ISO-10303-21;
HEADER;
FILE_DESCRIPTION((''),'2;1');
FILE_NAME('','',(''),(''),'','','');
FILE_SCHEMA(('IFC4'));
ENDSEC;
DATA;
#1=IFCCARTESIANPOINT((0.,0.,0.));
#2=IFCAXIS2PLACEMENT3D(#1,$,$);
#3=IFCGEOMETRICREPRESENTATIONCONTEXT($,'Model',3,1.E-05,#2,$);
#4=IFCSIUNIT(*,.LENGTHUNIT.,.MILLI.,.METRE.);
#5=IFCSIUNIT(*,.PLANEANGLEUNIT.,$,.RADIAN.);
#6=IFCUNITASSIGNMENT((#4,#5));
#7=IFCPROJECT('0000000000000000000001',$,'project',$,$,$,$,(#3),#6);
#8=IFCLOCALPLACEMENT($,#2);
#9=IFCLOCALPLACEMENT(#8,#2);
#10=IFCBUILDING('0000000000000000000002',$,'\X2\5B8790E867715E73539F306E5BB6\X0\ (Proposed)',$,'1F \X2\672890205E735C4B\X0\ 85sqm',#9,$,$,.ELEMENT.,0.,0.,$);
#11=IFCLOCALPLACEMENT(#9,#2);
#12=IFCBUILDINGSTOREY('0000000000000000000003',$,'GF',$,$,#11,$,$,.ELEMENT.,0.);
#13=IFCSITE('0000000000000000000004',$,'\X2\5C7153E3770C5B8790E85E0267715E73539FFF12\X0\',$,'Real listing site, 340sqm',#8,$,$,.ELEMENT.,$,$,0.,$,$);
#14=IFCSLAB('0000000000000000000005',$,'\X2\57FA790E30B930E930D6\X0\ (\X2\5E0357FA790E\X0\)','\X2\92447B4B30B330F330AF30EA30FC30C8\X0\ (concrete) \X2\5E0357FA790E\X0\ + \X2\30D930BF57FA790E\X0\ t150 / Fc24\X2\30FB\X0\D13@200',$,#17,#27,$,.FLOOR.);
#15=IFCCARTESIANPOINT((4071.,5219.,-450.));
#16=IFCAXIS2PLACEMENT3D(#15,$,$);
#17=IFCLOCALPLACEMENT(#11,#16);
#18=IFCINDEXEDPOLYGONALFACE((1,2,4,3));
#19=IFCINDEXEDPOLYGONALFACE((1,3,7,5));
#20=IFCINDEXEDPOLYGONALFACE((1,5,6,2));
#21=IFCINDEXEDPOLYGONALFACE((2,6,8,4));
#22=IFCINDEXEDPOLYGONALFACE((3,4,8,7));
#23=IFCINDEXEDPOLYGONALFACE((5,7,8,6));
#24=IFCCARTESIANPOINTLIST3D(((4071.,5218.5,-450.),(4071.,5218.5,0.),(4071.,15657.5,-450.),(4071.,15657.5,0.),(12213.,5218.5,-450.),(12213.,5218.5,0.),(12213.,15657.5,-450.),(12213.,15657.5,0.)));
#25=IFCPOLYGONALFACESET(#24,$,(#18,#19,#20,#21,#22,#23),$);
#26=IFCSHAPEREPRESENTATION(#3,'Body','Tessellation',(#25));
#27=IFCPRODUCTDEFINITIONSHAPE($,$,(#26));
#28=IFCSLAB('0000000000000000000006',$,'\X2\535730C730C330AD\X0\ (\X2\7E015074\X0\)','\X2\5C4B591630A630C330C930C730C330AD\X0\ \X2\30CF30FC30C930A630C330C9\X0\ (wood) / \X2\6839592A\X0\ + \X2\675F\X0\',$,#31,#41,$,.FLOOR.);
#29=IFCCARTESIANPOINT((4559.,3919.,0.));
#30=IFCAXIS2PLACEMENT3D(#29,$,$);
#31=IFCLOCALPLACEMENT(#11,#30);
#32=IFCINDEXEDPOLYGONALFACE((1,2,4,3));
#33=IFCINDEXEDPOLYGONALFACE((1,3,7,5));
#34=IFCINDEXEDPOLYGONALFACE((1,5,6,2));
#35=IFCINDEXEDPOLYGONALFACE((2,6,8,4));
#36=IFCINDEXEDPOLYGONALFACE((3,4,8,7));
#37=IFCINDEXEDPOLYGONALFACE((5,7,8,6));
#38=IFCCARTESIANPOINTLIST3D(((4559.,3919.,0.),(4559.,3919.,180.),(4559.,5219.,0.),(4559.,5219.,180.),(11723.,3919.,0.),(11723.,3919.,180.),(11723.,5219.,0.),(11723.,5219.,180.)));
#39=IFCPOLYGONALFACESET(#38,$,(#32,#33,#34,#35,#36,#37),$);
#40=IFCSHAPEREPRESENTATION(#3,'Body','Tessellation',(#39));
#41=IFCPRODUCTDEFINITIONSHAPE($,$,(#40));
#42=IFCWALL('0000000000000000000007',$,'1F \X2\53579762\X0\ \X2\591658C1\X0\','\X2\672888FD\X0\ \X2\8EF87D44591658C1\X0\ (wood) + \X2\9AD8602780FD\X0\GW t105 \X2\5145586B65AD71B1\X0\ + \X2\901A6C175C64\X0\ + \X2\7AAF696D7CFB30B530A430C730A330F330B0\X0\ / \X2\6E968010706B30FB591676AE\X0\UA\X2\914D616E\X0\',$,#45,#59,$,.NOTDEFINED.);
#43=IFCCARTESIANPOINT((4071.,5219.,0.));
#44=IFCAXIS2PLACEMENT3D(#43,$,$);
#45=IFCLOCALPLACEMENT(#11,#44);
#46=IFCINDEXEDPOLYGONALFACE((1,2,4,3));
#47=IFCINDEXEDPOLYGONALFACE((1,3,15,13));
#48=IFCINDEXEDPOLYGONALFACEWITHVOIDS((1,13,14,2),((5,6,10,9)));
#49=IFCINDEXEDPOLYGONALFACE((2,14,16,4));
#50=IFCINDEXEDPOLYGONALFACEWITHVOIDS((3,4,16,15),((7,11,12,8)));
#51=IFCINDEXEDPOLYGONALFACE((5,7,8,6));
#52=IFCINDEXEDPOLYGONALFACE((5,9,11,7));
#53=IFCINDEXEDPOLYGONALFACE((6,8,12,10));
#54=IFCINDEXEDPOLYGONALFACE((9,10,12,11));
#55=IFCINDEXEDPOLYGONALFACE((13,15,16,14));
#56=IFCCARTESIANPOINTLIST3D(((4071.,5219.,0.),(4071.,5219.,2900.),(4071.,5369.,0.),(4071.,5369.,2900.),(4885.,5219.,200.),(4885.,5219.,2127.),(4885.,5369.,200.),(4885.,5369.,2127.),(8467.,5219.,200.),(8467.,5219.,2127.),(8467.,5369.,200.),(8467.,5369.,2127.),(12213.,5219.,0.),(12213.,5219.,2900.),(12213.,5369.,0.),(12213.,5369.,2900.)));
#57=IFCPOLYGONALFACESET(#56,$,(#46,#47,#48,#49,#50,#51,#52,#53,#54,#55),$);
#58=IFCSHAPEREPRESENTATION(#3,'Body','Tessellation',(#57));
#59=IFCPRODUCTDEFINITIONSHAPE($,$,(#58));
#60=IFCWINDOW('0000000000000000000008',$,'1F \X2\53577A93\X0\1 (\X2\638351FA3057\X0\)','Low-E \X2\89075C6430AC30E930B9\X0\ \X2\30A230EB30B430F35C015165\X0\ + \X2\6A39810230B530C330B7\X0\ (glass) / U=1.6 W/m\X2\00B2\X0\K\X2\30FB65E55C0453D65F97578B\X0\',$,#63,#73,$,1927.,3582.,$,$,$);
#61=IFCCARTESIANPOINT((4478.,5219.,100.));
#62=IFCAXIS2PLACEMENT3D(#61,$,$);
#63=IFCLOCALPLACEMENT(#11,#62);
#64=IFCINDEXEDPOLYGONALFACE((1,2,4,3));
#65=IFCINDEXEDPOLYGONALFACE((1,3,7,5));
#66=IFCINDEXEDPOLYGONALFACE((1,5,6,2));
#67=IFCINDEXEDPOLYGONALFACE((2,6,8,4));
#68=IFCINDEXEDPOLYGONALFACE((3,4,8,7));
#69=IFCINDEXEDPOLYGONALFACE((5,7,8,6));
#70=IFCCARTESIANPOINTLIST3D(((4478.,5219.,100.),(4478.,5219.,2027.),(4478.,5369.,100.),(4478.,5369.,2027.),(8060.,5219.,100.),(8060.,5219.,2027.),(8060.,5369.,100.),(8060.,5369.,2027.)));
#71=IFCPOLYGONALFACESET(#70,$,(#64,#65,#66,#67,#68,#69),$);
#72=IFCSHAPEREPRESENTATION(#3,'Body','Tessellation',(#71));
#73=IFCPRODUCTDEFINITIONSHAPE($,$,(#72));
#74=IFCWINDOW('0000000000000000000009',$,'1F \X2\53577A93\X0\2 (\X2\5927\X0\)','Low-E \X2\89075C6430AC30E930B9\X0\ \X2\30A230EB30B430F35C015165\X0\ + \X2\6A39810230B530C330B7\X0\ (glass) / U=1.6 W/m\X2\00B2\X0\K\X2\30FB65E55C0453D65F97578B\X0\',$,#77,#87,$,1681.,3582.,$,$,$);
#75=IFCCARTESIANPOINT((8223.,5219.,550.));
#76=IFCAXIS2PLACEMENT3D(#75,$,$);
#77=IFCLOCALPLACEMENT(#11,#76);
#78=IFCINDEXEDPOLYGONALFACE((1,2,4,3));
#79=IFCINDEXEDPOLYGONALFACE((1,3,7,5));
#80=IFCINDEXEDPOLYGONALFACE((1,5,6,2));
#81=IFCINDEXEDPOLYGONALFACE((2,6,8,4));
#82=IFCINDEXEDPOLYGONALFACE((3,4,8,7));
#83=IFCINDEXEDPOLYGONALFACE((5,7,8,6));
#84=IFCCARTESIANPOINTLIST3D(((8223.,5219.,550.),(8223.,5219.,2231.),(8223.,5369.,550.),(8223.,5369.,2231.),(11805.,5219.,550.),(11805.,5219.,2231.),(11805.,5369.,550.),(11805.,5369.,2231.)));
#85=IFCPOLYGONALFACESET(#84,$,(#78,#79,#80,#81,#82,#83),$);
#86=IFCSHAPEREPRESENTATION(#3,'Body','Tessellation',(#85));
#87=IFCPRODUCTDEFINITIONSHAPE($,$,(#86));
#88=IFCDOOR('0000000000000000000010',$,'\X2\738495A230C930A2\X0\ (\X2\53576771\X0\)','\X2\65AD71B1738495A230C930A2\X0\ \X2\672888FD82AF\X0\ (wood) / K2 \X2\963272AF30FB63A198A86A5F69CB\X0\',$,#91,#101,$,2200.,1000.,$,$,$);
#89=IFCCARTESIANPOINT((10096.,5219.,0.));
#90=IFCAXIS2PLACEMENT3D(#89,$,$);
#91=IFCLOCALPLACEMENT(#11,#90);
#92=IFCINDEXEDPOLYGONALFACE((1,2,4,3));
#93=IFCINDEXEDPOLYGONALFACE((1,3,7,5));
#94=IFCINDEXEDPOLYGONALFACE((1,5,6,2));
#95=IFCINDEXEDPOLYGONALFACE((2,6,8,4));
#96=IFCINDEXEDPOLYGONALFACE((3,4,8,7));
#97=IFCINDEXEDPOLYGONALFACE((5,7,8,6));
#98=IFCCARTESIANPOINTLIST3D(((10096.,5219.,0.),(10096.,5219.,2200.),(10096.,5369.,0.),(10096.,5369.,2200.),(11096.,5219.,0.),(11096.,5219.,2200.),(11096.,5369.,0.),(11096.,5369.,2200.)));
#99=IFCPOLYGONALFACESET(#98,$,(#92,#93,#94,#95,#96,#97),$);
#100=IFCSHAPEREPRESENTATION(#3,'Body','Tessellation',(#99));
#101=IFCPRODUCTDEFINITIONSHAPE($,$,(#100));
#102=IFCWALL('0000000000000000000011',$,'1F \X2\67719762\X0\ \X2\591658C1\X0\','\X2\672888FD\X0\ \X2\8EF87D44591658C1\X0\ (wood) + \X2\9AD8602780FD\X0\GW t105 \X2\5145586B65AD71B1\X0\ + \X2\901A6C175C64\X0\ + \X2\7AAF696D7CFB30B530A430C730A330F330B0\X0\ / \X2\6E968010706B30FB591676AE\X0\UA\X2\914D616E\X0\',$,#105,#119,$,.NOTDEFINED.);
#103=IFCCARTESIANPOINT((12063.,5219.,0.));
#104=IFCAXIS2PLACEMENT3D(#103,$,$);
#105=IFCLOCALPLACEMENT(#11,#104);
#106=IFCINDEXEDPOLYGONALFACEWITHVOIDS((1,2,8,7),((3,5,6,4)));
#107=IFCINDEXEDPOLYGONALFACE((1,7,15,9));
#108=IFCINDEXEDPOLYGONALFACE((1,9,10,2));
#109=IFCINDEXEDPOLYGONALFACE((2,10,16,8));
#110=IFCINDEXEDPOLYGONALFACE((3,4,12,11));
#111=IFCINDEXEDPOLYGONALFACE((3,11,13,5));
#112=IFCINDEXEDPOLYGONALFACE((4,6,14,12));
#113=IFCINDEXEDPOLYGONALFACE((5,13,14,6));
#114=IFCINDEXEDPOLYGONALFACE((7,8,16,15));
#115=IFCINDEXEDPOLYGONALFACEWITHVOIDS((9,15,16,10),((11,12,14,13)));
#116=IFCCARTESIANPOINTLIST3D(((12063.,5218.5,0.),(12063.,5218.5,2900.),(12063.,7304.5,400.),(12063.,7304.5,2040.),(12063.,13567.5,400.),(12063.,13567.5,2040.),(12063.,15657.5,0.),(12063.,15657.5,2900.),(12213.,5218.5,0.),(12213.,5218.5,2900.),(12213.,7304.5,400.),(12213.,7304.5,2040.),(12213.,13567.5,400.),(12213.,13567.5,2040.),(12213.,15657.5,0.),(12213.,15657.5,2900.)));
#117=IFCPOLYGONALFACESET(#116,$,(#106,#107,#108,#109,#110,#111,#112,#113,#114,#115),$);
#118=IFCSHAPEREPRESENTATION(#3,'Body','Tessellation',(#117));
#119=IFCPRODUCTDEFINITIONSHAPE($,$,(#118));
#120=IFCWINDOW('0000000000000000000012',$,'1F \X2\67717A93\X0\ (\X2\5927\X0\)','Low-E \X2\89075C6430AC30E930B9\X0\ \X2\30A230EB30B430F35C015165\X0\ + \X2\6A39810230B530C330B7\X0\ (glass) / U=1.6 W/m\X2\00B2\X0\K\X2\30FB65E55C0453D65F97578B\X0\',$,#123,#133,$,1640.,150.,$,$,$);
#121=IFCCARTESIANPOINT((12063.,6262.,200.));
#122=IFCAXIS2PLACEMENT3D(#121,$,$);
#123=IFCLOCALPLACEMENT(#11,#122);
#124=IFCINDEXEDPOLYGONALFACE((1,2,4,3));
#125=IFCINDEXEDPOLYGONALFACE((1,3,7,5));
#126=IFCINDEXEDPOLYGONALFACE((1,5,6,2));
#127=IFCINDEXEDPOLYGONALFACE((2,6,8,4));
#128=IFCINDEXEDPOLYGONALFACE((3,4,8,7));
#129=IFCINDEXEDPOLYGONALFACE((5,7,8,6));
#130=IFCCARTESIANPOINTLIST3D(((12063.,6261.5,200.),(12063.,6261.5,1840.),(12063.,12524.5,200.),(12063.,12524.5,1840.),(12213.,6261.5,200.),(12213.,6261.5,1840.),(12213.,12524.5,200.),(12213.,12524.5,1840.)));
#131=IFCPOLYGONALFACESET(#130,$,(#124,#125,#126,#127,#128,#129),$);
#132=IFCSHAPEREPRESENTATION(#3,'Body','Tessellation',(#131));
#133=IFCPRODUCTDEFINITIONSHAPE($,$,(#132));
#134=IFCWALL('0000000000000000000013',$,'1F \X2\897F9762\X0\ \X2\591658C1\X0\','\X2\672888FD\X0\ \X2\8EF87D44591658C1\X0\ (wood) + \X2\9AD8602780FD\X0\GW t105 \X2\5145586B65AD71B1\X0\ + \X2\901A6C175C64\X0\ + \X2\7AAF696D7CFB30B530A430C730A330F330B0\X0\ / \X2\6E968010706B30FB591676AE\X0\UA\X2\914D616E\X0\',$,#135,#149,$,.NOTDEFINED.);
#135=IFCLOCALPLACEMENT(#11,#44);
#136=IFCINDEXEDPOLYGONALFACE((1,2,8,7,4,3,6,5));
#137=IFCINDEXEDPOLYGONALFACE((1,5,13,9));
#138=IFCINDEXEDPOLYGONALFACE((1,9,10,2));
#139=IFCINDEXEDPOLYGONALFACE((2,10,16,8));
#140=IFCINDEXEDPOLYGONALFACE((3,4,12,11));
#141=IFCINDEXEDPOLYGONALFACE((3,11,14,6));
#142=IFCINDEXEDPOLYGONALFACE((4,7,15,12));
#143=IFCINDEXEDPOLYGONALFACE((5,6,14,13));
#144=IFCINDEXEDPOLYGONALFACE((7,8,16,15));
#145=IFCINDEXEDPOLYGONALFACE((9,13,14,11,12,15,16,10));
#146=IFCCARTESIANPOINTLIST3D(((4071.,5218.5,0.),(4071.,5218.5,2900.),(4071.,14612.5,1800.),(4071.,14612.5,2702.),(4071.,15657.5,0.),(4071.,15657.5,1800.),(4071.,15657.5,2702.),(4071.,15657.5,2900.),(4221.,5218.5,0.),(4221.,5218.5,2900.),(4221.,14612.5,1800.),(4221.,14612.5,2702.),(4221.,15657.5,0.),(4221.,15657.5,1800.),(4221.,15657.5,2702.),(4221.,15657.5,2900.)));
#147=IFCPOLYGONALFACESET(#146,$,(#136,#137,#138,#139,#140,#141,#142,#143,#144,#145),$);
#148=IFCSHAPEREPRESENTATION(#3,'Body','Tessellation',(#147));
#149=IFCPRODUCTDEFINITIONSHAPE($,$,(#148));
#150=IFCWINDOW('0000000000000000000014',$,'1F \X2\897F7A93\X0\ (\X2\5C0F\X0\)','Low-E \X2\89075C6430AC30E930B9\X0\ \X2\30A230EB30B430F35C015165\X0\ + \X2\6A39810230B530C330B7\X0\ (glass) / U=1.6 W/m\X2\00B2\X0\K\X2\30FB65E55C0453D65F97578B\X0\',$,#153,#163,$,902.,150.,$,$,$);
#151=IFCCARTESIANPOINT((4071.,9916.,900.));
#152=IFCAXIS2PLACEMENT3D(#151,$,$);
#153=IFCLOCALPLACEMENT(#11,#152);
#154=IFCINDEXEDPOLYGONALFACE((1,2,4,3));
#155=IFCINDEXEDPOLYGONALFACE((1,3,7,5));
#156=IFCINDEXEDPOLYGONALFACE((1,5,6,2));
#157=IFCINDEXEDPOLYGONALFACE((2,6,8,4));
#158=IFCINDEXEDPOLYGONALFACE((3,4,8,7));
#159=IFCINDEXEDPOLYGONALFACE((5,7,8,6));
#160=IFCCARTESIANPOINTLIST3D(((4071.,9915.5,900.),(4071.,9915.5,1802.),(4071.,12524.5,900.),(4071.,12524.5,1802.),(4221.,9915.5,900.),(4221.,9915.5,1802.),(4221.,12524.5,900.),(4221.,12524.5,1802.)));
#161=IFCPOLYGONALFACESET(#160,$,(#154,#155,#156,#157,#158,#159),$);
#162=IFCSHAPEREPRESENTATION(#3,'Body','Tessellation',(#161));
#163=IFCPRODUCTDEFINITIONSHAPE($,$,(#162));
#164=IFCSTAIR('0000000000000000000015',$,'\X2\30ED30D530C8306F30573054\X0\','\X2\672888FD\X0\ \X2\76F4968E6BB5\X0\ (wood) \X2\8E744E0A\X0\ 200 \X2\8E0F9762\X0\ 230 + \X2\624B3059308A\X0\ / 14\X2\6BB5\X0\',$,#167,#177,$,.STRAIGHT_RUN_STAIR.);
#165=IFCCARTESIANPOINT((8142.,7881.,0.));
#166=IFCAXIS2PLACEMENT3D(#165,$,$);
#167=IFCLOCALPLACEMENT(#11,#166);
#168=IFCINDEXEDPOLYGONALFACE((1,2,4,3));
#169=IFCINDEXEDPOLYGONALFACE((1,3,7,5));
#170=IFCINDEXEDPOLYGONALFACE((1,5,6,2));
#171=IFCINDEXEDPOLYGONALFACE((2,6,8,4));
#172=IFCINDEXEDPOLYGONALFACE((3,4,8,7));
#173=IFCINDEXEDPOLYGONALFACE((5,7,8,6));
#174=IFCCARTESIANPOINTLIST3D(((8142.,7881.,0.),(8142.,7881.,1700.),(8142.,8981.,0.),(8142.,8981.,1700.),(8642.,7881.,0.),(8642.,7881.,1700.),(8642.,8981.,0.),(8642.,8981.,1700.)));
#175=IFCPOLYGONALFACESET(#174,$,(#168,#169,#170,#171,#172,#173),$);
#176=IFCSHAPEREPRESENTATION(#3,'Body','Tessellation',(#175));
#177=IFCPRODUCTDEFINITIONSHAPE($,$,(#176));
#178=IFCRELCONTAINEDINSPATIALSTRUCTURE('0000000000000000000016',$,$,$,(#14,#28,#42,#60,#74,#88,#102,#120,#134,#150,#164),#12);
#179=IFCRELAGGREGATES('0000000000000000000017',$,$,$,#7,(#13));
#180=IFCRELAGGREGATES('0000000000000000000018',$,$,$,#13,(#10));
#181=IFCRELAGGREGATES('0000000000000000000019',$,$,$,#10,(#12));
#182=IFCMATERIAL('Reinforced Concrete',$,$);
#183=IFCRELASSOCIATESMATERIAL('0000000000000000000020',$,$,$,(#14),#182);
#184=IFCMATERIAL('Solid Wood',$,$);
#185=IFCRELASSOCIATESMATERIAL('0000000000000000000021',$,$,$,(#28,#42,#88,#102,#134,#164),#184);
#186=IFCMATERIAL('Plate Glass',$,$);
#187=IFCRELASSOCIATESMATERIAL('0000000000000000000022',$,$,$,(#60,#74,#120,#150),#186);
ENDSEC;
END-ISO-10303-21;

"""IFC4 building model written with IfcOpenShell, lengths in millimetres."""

from ifc_helpers import new_model, si_unit, frame, frame_2d, origin, place, context, project, spatial, rectangle, extrude, material, element, fill, save


model = new_model("IFC4")

# Units and contexts
model_context = context("Model", 3, precision=1e-05, world=origin())
ifc_project = project(units=[si_unit("LENGTHUNIT", "METRE", prefix="MILLI"), si_unit("PLANEANGLEUNIT", "RADIAN")], contexts=[model_context])

# Site, building, storey
site_placement = place(None, origin())
site = spatial("IfcSite", under=ifc_project, at=site_placement, Name="山口県宇部市東平原２", ObjectType="Real listing site, 340sqm", CompositionType="ELEMENT", RefElevation=0.0)
building_placement = place(site_placement, origin())
building = spatial("IfcBuilding", under=site, at=building_placement, Name="宇部東平原の家 (Proposed)", ObjectType="1F 木造平屋 85sqm", CompositionType="ELEMENT", ElevationOfRefHeight=0.0, ElevationOfTerrain=0.0)
storey_placement = place(building_placement, origin())
storey = spatial("IfcBuildingStorey", under=building, at=storey_placement, Name="GF", CompositionType="ELEMENT", Elevation=0.0)

# Slabs
ifc_material_1 = material(Name="Reinforced Concrete")
slab_1_placement = place(storey_placement, frame((4071.0, 5219.0, -450.0)))
element("IfcSlab", 1, at=slab_1_placement, inside=storey, material=ifc_material_1, Name="基礎スラブ (布基礎)", Description="鉄筋コンクリート (concrete) 布基礎 + ベタ基礎 t150 / Fc24・D13@200", PredefinedType="FLOOR", context=model_context, shape_type="SweptSolid", body=[
    extrude(rectangle(XDim=8142.0, YDim=10439.0, at=frame_2d((4071.0, 5219.0))), frame((4071.0, 5219.0, -450.0)), (0.0, 0.0, 1.0), 450.0),
])
ifc_material_2 = material(Name="Solid Wood")
slab_2_placement = place(storey_placement, frame((4559.0, 3919.0, 0.0)))
element("IfcSlab", 2, at=slab_2_placement, inside=storey, material=ifc_material_2, Name="南デッキ (縁側)", Description="屋外ウッドデッキ ハードウッド (wood) / 根太 + 束", PredefinedType="FLOOR", context=model_context, shape_type="SweptSolid", body=[
    extrude(rectangle(XDim=7164.0, YDim=1300.0, at=frame_2d((3582.0, 650.0))), frame((4559.0, 3919.0, 0.0)), (0.0, 0.0, 1.0), 180.0),
])

# Wall, openings, windows, door
wall_1_placement = place(storey_placement, frame((4071.0, 5219.0, 0.0)))
wall_1 = element("IfcWall", 3, at=wall_1_placement, inside=storey, material=ifc_material_2, Name="1F 南面 外壁", Description="木製 軸組外壁 (wood) + 高性能GW t105 充填断熱 + 通気層 + 窯業系サイディング / 準耐火・外皮UA配慮", PredefinedType="NOTDEFINED", context=model_context, shape_type="SweptSolid", body=[
    extrude(rectangle(XDim=8142.0, YDim=150.0, at=frame_2d((4071.0, 75.0))), frame((4071.0, 5219.0, 0.0)), (0.0, 0.0, 1.0), 2900.0),
])
opening_1_placement = place(storey_placement, frame((4478.0, 5219.0, 100.0)))
opening_1 = element("IfcOpeningElement", 4, at=opening_1_placement, cuts=wall_1, PredefinedType="NOTDEFINED", context=model_context, shape_type="SweptSolid", body=[
    extrude(rectangle(XDim=3582.0, YDim=150.0, at=frame_2d((1791.0, 75.0))), frame((4478.0, 5219.0, 100.0)), (0.0, 0.0, 1.0), 1927.0),
])
opening_2_placement = place(storey_placement, frame((8223.0, 5219.0, 550.0)))
opening_2 = element("IfcOpeningElement", 5, at=opening_2_placement, cuts=wall_1, PredefinedType="NOTDEFINED", context=model_context, shape_type="SweptSolid", body=[
    extrude(rectangle(XDim=3582.0, YDim=150.0, at=frame_2d((1791.0, 75.0))), frame((8223.0, 5219.0, 550.0)), (0.0, 0.0, 1.0), 1681.0),
])
opening_3_placement = place(storey_placement, frame((10096.0, 5219.0, 0.0)))
opening_3 = element("IfcOpeningElement", 6, at=opening_3_placement, cuts=wall_1, PredefinedType="NOTDEFINED", context=model_context, shape_type="SweptSolid", body=[
    extrude(rectangle(XDim=1000.0, YDim=150.0, at=frame_2d((500.0, 75.0))), frame((10096.0, 5219.0, 0.0)), (0.0, 0.0, 1.0), 2200.0),
])
ifc_material_3 = material(Name="Plate Glass")
window_1_placement = place(storey_placement, frame((4478.0, 5219.0, 100.0)))
window_1 = element("IfcWindow", 7, at=window_1_placement, inside=storey, material=ifc_material_3, Name="1F 南窓1 (掃出し)", Description="Low-E 複層ガラス アルゴン封入 + 樹脂サッシ (glass) / U=1.6 W/m²K・日射取得型", OverallHeight=1927.0, OverallWidth=3582.0, context=model_context, shape_type="SweptSolid", body=[
    extrude(rectangle(XDim=3582.0, YDim=150.0, at=frame_2d((1791.0, 75.0))), frame((4478.0, 5219.0, 100.0)), (0.0, 0.0, 1.0), 1927.0),
])
fill(opening_1, window_1)
window_2_placement = place(storey_placement, frame((8223.0, 5219.0, 550.0)))
window_2 = element("IfcWindow", 8, at=window_2_placement, inside=storey, material=ifc_material_3, Name="1F 南窓2 (大)", Description="Low-E 複層ガラス アルゴン封入 + 樹脂サッシ (glass) / U=1.6 W/m²K・日射取得型", OverallHeight=1681.0, OverallWidth=3582.0, context=model_context, shape_type="SweptSolid", body=[
    extrude(rectangle(XDim=3582.0, YDim=150.0, at=frame_2d((1791.0, 75.0))), frame((8223.0, 5219.0, 550.0)), (0.0, 0.0, 1.0), 1681.0),
])
fill(opening_2, window_2)
door_placement = place(storey_placement, frame((10096.0, 5219.0, 0.0)))
door = element("IfcDoor", 9, at=door_placement, inside=storey, material=ifc_material_2, Name="玄関ドア (南東)", Description="断熱玄関ドア 木製芯 (wood) / K2 防犯・採風機構", OverallHeight=2200.0, OverallWidth=1000.0, context=model_context, shape_type="SweptSolid", body=[
    extrude(rectangle(XDim=1000.0, YDim=150.0, at=frame_2d((500.0, 75.0))), frame((10096.0, 5219.0, 0.0)), (0.0, 0.0, 1.0), 2200.0),
])
fill(opening_3, door)

# Walls, openings, windows
wall_2_placement = place(storey_placement, frame((12063.0, 5219.0, 0.0)))
wall_2 = element("IfcWall", 10, at=wall_2_placement, inside=storey, material=ifc_material_2, Name="1F 東面 外壁", Description="木製 軸組外壁 (wood) + 高性能GW t105 充填断熱 + 通気層 + 窯業系サイディング / 準耐火・外皮UA配慮", PredefinedType="NOTDEFINED", context=model_context, shape_type="SweptSolid", body=[
    extrude(rectangle(XDim=150.0, YDim=10439.0, at=frame_2d((75.0, 5219.0))), frame((12063.0, 5219.0, 0.0)), (0.0, 0.0, 1.0), 2900.0),
])
opening_4_placement = place(storey_placement, frame((12063.0, 6262.0, 200.0)))
opening_4 = element("IfcOpeningElement", 11, at=opening_4_placement, cuts=wall_2, PredefinedType="NOTDEFINED", context=model_context, shape_type="SweptSolid", body=[
    extrude(rectangle(XDim=150.0, YDim=6263.0, at=frame_2d((75.0, 3131.0))), frame((12063.0, 6262.0, 200.0)), (0.0, 0.0, 1.0), 1640.0),
])
window_3_placement = place(storey_placement, frame((12063.0, 6262.0, 200.0)))
window_3 = element("IfcWindow", 12, at=window_3_placement, inside=storey, material=ifc_material_3, Name="1F 東窓 (大)", Description="Low-E 複層ガラス アルゴン封入 + 樹脂サッシ (glass) / U=1.6 W/m²K・日射取得型", OverallHeight=1640.0, OverallWidth=150.0, context=model_context, shape_type="SweptSolid", body=[
    extrude(rectangle(XDim=150.0, YDim=6263.0, at=frame_2d((75.0, 3131.0))), frame((12063.0, 6262.0, 200.0)), (0.0, 0.0, 1.0), 1640.0),
])
fill(opening_4, window_3)
wall_3_placement = place(storey_placement, frame((4071.0, 5219.0, 0.0)))
wall_3 = element("IfcWall", 13, at=wall_3_placement, inside=storey, material=ifc_material_2, Name="1F 西面 外壁", Description="木製 軸組外壁 (wood) + 高性能GW t105 充填断熱 + 通気層 + 窯業系サイディング / 準耐火・外皮UA配慮", PredefinedType="NOTDEFINED", context=model_context, shape_type="SweptSolid", body=[
    extrude(rectangle(XDim=150.0, YDim=10439.0, at=frame_2d((75.0, 5219.0))), frame((4071.0, 5219.0, 0.0)), (0.0, 0.0, 1.0), 2900.0),
])
opening_5_placement = place(storey_placement, frame((4071.0, 9916.0, 900.0)))
opening_5 = element("IfcOpeningElement", 14, at=opening_5_placement, cuts=wall_3, PredefinedType="NOTDEFINED", context=model_context, shape_type="SweptSolid", body=[
    extrude(rectangle(XDim=150.0, YDim=2609.0, at=frame_2d((75.0, 1304.0))), frame((4071.0, 9916.0, 900.0)), (0.0, 0.0, 1.0), 902.0),
])
window_4_placement = place(storey_placement, frame((4071.0, 9916.0, 900.0)))
window_4 = element("IfcWindow", 15, at=window_4_placement, inside=storey, material=ifc_material_3, Name="1F 西窓 (小)", Description="Low-E 複層ガラス アルゴン封入 + 樹脂サッシ (glass) / U=1.6 W/m²K・日射取得型", OverallHeight=902.0, OverallWidth=150.0, context=model_context, shape_type="SweptSolid", body=[
    extrude(rectangle(XDim=150.0, YDim=2609.0, at=frame_2d((75.0, 1304.0))), frame((4071.0, 9916.0, 900.0)), (0.0, 0.0, 1.0), 902.0),
])
fill(opening_5, window_4)

# Stair
stair_placement = place(storey_placement, frame((8142.0, 7881.0, 0.0)))
element("IfcStair", 16, at=stair_placement, inside=storey, material=ifc_material_2, Name="ロフトはしご", Description="木製 直階段 (wood) 蹴上 200 踏面 230 + 手すり / 14段", PredefinedType="STRAIGHT_RUN_STAIR", context=model_context, shape_type="SweptSolid", body=[
    extrude(rectangle(XDim=500.0, YDim=1100.0, at=frame_2d((250.0, 550.0))), frame((8142.0, 7881.0, 0.0)), (0.0, 0.0, 1.0), 1700.0),
])

save(model, "model.ifc")
